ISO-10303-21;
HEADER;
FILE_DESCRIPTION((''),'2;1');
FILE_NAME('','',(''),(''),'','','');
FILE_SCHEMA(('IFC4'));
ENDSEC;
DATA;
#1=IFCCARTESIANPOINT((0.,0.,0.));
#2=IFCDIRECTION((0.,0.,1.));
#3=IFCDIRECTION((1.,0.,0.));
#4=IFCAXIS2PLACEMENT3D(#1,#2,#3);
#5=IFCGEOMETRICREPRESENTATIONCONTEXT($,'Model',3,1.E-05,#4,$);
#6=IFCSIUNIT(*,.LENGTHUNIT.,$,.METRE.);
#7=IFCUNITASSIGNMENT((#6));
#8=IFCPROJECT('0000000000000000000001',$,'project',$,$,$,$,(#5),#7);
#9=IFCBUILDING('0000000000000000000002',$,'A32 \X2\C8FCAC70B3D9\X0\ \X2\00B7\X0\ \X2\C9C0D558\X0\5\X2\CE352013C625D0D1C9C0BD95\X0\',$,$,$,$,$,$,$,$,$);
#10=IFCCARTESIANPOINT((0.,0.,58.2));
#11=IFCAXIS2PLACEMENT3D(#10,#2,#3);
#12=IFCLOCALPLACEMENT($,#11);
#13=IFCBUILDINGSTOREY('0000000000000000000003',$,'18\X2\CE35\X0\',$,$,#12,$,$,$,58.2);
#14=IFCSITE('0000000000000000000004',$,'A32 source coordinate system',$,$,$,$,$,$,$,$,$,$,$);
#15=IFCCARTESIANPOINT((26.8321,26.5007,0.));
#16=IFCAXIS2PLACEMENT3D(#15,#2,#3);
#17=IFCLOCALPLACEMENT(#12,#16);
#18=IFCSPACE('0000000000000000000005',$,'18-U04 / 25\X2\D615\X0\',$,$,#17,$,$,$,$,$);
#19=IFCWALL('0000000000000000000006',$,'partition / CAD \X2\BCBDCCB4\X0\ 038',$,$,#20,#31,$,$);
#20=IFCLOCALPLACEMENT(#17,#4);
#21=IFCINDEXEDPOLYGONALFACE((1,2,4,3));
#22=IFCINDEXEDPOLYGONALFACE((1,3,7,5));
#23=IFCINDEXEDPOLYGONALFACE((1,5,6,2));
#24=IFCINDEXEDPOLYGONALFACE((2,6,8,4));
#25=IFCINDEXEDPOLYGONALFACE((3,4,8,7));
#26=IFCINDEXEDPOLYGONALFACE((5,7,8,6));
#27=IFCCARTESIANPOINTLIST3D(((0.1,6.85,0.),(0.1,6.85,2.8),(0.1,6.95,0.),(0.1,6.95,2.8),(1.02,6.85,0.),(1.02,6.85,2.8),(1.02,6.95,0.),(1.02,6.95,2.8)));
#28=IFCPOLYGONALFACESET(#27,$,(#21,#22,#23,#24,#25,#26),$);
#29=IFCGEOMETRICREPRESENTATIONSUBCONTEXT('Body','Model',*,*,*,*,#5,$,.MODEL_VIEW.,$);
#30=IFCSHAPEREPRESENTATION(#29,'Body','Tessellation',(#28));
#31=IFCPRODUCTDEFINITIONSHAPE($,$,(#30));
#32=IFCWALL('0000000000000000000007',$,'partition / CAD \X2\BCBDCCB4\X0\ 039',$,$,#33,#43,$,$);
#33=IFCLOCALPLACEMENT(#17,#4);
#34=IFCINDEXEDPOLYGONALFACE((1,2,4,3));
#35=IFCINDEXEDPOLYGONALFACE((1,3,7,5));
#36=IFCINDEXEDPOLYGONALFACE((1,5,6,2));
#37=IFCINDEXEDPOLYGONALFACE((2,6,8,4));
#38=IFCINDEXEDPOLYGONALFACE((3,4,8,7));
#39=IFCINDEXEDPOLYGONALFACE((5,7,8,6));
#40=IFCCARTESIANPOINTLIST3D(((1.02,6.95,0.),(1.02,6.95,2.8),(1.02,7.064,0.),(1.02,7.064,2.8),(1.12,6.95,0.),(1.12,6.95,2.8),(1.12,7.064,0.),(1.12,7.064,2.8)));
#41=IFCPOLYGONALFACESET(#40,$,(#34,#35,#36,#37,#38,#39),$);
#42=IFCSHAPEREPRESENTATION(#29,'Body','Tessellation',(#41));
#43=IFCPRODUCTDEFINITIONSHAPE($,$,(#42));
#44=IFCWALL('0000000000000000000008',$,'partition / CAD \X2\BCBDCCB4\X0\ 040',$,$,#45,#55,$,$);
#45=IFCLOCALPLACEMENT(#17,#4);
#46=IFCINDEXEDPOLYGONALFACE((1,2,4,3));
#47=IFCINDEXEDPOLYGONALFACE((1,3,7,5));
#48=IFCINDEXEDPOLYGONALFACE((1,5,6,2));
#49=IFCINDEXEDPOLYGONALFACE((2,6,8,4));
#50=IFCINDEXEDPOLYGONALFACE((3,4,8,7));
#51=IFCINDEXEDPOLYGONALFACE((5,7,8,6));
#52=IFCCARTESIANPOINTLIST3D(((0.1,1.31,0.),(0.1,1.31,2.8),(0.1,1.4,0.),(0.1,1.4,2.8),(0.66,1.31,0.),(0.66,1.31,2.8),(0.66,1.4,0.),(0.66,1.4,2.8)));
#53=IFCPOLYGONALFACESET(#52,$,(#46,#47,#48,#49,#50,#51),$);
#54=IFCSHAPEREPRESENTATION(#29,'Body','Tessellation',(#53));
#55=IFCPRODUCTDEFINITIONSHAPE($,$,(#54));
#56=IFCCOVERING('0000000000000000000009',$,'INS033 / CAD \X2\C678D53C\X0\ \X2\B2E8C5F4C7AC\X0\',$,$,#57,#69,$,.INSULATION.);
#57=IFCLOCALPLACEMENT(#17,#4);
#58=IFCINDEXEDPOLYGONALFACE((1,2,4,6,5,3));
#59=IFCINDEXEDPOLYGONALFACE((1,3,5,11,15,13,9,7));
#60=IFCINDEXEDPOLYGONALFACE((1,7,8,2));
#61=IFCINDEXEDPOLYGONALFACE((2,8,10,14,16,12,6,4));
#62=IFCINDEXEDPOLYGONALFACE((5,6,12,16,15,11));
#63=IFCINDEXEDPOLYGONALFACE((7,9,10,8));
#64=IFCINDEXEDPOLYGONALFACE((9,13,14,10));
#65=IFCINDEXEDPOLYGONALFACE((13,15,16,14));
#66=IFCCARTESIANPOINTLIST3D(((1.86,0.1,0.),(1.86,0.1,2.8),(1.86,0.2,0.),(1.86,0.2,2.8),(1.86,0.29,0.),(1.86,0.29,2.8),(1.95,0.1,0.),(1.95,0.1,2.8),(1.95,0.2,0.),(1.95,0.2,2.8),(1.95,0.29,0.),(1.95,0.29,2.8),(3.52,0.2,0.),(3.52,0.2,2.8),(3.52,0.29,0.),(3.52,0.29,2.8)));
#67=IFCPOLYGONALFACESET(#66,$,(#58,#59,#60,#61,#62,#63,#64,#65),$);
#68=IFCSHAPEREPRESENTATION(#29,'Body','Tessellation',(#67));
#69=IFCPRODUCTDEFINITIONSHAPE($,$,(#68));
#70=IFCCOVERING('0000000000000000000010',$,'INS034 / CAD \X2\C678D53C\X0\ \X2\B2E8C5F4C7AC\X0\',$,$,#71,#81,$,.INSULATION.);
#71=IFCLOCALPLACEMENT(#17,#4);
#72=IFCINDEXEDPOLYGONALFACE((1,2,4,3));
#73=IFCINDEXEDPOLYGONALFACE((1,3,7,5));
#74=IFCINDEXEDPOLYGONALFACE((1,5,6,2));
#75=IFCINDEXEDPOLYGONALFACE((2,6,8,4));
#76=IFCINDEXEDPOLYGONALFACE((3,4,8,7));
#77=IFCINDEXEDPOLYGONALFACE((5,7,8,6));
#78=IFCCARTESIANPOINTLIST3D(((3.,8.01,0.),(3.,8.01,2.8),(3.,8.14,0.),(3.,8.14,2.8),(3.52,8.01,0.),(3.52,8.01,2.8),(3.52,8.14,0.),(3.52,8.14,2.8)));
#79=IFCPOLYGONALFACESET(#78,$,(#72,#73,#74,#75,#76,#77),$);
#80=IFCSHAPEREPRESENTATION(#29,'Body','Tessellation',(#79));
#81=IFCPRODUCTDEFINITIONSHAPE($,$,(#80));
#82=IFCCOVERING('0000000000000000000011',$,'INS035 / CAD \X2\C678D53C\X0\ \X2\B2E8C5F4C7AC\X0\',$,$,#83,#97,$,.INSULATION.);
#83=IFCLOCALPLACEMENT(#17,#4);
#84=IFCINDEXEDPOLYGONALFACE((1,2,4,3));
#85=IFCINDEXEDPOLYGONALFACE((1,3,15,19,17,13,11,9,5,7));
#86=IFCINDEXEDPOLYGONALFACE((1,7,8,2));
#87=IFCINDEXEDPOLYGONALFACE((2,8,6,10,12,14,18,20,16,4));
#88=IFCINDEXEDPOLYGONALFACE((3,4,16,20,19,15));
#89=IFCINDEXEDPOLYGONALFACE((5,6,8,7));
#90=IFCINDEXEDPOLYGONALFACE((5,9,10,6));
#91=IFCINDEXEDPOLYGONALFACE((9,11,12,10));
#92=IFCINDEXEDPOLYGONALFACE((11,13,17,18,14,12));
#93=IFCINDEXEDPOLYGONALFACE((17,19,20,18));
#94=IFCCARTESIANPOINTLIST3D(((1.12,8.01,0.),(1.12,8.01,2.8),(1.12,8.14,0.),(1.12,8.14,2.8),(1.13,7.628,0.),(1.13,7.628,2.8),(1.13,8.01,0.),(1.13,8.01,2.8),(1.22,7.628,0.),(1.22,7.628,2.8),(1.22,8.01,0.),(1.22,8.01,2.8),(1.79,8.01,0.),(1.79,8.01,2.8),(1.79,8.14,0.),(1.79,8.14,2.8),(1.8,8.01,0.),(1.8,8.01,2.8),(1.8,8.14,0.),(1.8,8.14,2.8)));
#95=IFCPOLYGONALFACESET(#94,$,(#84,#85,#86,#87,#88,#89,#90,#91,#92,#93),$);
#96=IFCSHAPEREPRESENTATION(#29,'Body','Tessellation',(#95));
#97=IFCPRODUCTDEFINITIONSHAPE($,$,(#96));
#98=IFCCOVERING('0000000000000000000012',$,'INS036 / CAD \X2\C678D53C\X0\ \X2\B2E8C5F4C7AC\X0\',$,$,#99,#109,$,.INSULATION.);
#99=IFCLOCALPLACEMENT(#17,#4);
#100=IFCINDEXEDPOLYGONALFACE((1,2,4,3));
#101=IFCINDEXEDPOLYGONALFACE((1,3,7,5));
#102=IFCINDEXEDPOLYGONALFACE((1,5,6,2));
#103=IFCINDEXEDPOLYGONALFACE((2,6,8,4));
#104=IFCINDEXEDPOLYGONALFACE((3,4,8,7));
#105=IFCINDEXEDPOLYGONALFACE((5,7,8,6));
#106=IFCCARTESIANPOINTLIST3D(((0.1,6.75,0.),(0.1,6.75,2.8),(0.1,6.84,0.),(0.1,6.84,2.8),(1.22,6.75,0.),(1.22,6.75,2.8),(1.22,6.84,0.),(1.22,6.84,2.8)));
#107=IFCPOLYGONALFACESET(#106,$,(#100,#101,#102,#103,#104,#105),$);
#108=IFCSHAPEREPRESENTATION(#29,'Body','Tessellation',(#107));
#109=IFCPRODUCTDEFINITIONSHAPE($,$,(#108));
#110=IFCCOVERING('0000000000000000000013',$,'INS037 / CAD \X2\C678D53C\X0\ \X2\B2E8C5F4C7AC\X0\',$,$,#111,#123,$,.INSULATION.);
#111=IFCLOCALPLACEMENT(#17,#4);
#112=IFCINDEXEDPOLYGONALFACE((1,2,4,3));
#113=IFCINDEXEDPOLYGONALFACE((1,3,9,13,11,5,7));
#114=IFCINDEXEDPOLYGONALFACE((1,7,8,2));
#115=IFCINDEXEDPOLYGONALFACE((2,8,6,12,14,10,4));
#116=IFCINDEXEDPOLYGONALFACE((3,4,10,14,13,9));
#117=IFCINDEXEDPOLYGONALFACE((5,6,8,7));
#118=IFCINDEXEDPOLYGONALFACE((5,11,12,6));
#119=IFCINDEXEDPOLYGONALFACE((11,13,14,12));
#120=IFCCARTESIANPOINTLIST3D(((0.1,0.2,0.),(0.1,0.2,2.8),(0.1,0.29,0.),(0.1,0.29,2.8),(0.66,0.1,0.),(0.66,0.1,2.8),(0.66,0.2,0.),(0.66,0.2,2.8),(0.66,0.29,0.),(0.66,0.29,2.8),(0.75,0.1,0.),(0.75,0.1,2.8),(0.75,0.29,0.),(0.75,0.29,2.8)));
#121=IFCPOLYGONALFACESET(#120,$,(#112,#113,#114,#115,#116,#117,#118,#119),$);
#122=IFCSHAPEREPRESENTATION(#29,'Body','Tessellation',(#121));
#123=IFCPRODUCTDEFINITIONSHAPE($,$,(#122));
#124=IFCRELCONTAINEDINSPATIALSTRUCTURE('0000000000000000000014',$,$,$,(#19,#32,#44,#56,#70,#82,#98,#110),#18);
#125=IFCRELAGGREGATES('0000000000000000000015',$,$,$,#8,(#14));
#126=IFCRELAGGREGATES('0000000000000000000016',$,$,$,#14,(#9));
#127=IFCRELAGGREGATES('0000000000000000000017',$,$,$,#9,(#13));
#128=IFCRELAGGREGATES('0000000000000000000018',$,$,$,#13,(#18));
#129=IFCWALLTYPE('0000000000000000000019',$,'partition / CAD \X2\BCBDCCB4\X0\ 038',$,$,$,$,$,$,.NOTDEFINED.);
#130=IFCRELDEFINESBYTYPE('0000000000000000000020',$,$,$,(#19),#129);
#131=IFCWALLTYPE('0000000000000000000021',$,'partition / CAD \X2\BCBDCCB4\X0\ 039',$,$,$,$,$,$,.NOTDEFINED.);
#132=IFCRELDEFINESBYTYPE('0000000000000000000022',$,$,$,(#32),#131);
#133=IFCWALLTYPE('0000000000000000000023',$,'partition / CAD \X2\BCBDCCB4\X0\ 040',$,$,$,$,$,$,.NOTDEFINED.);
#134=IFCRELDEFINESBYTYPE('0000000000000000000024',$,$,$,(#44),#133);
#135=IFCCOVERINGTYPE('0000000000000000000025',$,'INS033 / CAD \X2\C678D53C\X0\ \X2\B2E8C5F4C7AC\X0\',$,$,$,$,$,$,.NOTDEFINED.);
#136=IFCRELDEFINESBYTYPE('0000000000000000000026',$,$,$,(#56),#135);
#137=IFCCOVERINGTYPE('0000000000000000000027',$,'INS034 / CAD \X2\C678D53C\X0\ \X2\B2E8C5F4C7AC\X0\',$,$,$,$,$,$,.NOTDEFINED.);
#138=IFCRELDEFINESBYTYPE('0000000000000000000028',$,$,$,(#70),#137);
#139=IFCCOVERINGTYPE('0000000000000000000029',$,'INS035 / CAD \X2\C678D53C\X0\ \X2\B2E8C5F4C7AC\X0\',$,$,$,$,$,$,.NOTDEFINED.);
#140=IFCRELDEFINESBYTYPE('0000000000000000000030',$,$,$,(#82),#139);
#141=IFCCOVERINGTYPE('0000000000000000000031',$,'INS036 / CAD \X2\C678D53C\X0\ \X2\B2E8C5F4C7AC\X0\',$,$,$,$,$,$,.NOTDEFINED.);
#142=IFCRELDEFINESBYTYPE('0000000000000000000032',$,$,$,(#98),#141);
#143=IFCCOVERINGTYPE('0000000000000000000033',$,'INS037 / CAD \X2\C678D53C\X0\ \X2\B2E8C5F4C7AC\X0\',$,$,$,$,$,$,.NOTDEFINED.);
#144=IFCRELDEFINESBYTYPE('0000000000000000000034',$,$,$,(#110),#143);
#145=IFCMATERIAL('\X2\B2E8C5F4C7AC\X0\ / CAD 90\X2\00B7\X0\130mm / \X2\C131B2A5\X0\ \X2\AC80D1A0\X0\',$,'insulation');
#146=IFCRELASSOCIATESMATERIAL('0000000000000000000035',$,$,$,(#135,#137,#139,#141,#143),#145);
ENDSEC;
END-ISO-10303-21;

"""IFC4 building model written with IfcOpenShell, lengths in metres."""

from ifc_helpers import new_model, si_unit, frame, origin, origin_with_axes, place, context, subcontext, project, spatial, polyline, outline, extrude, source, transform, mapped, material, type_object, type_shapes, element, save


model = new_model("IFC4")

# Units and contexts
model_context = context("Model", 3, precision=1e-05, world=origin_with_axes())
body_context = subcontext(model_context, "Body", "Model", "MODEL_VIEW")
ifc_project = project(units=[si_unit("LENGTHUNIT", "METRE")], contexts=[model_context])

# Site, building, storey, space
storey_placement = place(None, frame((0.0, 0.0, 58.2), z_axis=(0.0, 0.0, 1.0), x_axis=(1.0, 0.0, 0.0)))
space_placement = place(storey_placement, frame((26.8321, 26.5007, 0.0), z_axis=(0.0, 0.0, 1.0), x_axis=(1.0, 0.0, 0.0)))
site = spatial("IfcSite", under=ifc_project, Name="A32 source coordinate system")
building = spatial("IfcBuilding", under=site, Name="A32 주거동 · 지하5층–옥탑지붕")
storey = spatial("IfcBuildingStorey", under=building, at=storey_placement, Name="18층", Elevation=58.2)
space = spatial("IfcSpace", under=storey, at=space_placement, Name="18-U04 / 25형")

# Walls
wall_type_1 = type_object("IfcWallType", Name="partition / CAD 벽체 038", PredefinedType="NOTDEFINED")
shared_shape_1 = source(origin(), body_context, "Body", "SweptSolid", [
    extrude(outline(polyline([(0.1, 6.95), (1.02, 6.95), (1.02, 6.85), (0.1, 6.85), (0.1, 6.95)])), origin(), (0.0, 0.0, 1.0), 2.8),
])
type_shapes(wall_type_1, [shared_shape_1])
wall_1_placement = place(space_placement, origin_with_axes())
element("IfcWall", 1, at=wall_1_placement, inside=space, type_object=wall_type_1, Name="partition / CAD 벽체 038", context=body_context, shape_type="MappedRepresentation", body=[
    mapped(shared_shape_1, transform((0.0, 0.0, 0.0), scale=1.0)),
])
wall_type_2 = type_object("IfcWallType", Name="partition / CAD 벽체 039", PredefinedType="NOTDEFINED")
shared_shape_2 = source(origin(), body_context, "Body", "SweptSolid", [
    extrude(outline(polyline([(1.02, 6.95), (1.02, 7.064), (1.12, 7.064), (1.12, 6.95), (1.02, 6.95)])), origin(), (0.0, 0.0, 1.0), 2.8),
])
type_shapes(wall_type_2, [shared_shape_2])
wall_2_placement = place(space_placement, origin_with_axes())
element("IfcWall", 2, at=wall_2_placement, inside=space, type_object=wall_type_2, Name="partition / CAD 벽체 039", context=body_context, shape_type="MappedRepresentation", body=[
    mapped(shared_shape_2, transform((0.0, 0.0, 0.0), scale=1.0)),
])
wall_type_3 = type_object("IfcWallType", Name="partition / CAD 벽체 040", PredefinedType="NOTDEFINED")
shared_shape_3 = source(origin(), body_context, "Body", "SweptSolid", [
    extrude(outline(polyline([(0.1, 1.4), (0.66, 1.4), (0.66, 1.31), (0.1, 1.31), (0.1, 1.4)])), origin(), (0.0, 0.0, 1.0), 2.8),
])
type_shapes(wall_type_3, [shared_shape_3])
wall_3_placement = place(space_placement, origin_with_axes())
element("IfcWall", 3, at=wall_3_placement, inside=space, type_object=wall_type_3, Name="partition / CAD 벽체 040", context=body_context, shape_type="MappedRepresentation", body=[
    mapped(shared_shape_3, transform((0.0, 0.0, 0.0), scale=1.0)),
])

# Coverings
ifc_material = material(Name="단열재 / CAD 90·130mm / 성능 검토", Category="insulation")
covering_type_1 = type_object("IfcCoveringType", Name="INS033 / CAD 외피 단열재", PredefinedType="NOTDEFINED", material=ifc_material)
shared_shape_4 = source(origin(), body_context, "Body", "SweptSolid", [
    extrude(outline(polyline([(1.95, 0.29), (3.52, 0.29), (3.52, 0.2), (1.95, 0.2), (1.95, 0.1), (1.86, 0.1), (1.86, 0.2), (1.86, 0.29), (1.95, 0.29)])), origin(), (0.0, 0.0, 1.0), 2.8),
])
type_shapes(covering_type_1, [shared_shape_4])
covering_1_placement = place(space_placement, origin_with_axes())
element("IfcCovering", 4, at=covering_1_placement, inside=space, type_object=covering_type_1, Name="INS033 / CAD 외피 단열재", PredefinedType="INSULATION", context=body_context, shape_type="MappedRepresentation", body=[
    mapped(shared_shape_4, transform((0.0, 0.0, 0.0), scale=1.0)),
])
covering_type_2 = type_object("IfcCoveringType", Name="INS034 / CAD 외피 단열재", PredefinedType="NOTDEFINED", material=ifc_material)
shared_shape_5 = source(origin(), body_context, "Body", "SweptSolid", [
    extrude(outline(polyline([(3.52, 8.01), (3.0, 8.01), (3.0, 8.14), (3.52, 8.14), (3.52, 8.01)])), origin(), (0.0, 0.0, 1.0), 2.8),
])
type_shapes(covering_type_2, [shared_shape_5])
covering_2_placement = place(space_placement, origin_with_axes())
element("IfcCovering", 5, at=covering_2_placement, inside=space, type_object=covering_type_2, Name="INS034 / CAD 외피 단열재", PredefinedType="INSULATION", context=body_context, shape_type="MappedRepresentation", body=[
    mapped(shared_shape_5, transform((0.0, 0.0, 0.0), scale=1.0)),
])
covering_type_3 = type_object("IfcCoveringType", Name="INS035 / CAD 외피 단열재", PredefinedType="NOTDEFINED", material=ifc_material)
shared_shape_6 = source(origin(), body_context, "Body", "SweptSolid", [
    extrude(outline(polyline([(1.8, 8.01), (1.79, 8.01), (1.22, 8.01), (1.22, 7.628), (1.13, 7.628), (1.13, 8.01), (1.12, 8.01), (1.12, 8.14), (1.79, 8.14), (1.8, 8.14), (1.8, 8.01)])), origin(), (0.0, 0.0, 1.0), 2.8),
])
type_shapes(covering_type_3, [shared_shape_6])
covering_3_placement = place(space_placement, origin_with_axes())
element("IfcCovering", 6, at=covering_3_placement, inside=space, type_object=covering_type_3, Name="INS035 / CAD 외피 단열재", PredefinedType="INSULATION", context=body_context, shape_type="MappedRepresentation", body=[
    mapped(shared_shape_6, transform((0.0, 0.0, 0.0), scale=1.0)),
])
covering_type_4 = type_object("IfcCoveringType", Name="INS036 / CAD 외피 단열재", PredefinedType="NOTDEFINED", material=ifc_material)
shared_shape_7 = source(origin(), body_context, "Body", "SweptSolid", [
    extrude(outline(polyline([(1.22, 6.84), (1.22, 6.75), (0.1, 6.75), (0.1, 6.84), (1.22, 6.84)])), origin(), (0.0, 0.0, 1.0), 2.8),
])
type_shapes(covering_type_4, [shared_shape_7])
covering_4_placement = place(space_placement, origin_with_axes())
element("IfcCovering", 7, at=covering_4_placement, inside=space, type_object=covering_type_4, Name="INS036 / CAD 외피 단열재", PredefinedType="INSULATION", context=body_context, shape_type="MappedRepresentation", body=[
    mapped(shared_shape_7, transform((0.0, 0.0, 0.0), scale=1.0)),
])
covering_type_5 = type_object("IfcCoveringType", Name="INS037 / CAD 외피 단열재", PredefinedType="NOTDEFINED", material=ifc_material)
shared_shape_8 = source(origin(), body_context, "Body", "SweptSolid", [
    extrude(outline(polyline([(0.1, 0.2), (0.1, 0.29), (0.66, 0.29), (0.75, 0.29), (0.75, 0.1), (0.66, 0.1), (0.66, 0.2), (0.1, 0.2)])), origin(), (0.0, 0.0, 1.0), 2.8),
])
type_shapes(covering_type_5, [shared_shape_8])
covering_5_placement = place(space_placement, origin_with_axes())
element("IfcCovering", 8, at=covering_5_placement, inside=space, type_object=covering_type_5, Name="INS037 / CAD 외피 단열재", PredefinedType="INSULATION", context=body_context, shape_type="MappedRepresentation", body=[
    mapped(shared_shape_8, transform((0.0, 0.0, 0.0), scale=1.0)),
])

save(model, "model.ifc")
